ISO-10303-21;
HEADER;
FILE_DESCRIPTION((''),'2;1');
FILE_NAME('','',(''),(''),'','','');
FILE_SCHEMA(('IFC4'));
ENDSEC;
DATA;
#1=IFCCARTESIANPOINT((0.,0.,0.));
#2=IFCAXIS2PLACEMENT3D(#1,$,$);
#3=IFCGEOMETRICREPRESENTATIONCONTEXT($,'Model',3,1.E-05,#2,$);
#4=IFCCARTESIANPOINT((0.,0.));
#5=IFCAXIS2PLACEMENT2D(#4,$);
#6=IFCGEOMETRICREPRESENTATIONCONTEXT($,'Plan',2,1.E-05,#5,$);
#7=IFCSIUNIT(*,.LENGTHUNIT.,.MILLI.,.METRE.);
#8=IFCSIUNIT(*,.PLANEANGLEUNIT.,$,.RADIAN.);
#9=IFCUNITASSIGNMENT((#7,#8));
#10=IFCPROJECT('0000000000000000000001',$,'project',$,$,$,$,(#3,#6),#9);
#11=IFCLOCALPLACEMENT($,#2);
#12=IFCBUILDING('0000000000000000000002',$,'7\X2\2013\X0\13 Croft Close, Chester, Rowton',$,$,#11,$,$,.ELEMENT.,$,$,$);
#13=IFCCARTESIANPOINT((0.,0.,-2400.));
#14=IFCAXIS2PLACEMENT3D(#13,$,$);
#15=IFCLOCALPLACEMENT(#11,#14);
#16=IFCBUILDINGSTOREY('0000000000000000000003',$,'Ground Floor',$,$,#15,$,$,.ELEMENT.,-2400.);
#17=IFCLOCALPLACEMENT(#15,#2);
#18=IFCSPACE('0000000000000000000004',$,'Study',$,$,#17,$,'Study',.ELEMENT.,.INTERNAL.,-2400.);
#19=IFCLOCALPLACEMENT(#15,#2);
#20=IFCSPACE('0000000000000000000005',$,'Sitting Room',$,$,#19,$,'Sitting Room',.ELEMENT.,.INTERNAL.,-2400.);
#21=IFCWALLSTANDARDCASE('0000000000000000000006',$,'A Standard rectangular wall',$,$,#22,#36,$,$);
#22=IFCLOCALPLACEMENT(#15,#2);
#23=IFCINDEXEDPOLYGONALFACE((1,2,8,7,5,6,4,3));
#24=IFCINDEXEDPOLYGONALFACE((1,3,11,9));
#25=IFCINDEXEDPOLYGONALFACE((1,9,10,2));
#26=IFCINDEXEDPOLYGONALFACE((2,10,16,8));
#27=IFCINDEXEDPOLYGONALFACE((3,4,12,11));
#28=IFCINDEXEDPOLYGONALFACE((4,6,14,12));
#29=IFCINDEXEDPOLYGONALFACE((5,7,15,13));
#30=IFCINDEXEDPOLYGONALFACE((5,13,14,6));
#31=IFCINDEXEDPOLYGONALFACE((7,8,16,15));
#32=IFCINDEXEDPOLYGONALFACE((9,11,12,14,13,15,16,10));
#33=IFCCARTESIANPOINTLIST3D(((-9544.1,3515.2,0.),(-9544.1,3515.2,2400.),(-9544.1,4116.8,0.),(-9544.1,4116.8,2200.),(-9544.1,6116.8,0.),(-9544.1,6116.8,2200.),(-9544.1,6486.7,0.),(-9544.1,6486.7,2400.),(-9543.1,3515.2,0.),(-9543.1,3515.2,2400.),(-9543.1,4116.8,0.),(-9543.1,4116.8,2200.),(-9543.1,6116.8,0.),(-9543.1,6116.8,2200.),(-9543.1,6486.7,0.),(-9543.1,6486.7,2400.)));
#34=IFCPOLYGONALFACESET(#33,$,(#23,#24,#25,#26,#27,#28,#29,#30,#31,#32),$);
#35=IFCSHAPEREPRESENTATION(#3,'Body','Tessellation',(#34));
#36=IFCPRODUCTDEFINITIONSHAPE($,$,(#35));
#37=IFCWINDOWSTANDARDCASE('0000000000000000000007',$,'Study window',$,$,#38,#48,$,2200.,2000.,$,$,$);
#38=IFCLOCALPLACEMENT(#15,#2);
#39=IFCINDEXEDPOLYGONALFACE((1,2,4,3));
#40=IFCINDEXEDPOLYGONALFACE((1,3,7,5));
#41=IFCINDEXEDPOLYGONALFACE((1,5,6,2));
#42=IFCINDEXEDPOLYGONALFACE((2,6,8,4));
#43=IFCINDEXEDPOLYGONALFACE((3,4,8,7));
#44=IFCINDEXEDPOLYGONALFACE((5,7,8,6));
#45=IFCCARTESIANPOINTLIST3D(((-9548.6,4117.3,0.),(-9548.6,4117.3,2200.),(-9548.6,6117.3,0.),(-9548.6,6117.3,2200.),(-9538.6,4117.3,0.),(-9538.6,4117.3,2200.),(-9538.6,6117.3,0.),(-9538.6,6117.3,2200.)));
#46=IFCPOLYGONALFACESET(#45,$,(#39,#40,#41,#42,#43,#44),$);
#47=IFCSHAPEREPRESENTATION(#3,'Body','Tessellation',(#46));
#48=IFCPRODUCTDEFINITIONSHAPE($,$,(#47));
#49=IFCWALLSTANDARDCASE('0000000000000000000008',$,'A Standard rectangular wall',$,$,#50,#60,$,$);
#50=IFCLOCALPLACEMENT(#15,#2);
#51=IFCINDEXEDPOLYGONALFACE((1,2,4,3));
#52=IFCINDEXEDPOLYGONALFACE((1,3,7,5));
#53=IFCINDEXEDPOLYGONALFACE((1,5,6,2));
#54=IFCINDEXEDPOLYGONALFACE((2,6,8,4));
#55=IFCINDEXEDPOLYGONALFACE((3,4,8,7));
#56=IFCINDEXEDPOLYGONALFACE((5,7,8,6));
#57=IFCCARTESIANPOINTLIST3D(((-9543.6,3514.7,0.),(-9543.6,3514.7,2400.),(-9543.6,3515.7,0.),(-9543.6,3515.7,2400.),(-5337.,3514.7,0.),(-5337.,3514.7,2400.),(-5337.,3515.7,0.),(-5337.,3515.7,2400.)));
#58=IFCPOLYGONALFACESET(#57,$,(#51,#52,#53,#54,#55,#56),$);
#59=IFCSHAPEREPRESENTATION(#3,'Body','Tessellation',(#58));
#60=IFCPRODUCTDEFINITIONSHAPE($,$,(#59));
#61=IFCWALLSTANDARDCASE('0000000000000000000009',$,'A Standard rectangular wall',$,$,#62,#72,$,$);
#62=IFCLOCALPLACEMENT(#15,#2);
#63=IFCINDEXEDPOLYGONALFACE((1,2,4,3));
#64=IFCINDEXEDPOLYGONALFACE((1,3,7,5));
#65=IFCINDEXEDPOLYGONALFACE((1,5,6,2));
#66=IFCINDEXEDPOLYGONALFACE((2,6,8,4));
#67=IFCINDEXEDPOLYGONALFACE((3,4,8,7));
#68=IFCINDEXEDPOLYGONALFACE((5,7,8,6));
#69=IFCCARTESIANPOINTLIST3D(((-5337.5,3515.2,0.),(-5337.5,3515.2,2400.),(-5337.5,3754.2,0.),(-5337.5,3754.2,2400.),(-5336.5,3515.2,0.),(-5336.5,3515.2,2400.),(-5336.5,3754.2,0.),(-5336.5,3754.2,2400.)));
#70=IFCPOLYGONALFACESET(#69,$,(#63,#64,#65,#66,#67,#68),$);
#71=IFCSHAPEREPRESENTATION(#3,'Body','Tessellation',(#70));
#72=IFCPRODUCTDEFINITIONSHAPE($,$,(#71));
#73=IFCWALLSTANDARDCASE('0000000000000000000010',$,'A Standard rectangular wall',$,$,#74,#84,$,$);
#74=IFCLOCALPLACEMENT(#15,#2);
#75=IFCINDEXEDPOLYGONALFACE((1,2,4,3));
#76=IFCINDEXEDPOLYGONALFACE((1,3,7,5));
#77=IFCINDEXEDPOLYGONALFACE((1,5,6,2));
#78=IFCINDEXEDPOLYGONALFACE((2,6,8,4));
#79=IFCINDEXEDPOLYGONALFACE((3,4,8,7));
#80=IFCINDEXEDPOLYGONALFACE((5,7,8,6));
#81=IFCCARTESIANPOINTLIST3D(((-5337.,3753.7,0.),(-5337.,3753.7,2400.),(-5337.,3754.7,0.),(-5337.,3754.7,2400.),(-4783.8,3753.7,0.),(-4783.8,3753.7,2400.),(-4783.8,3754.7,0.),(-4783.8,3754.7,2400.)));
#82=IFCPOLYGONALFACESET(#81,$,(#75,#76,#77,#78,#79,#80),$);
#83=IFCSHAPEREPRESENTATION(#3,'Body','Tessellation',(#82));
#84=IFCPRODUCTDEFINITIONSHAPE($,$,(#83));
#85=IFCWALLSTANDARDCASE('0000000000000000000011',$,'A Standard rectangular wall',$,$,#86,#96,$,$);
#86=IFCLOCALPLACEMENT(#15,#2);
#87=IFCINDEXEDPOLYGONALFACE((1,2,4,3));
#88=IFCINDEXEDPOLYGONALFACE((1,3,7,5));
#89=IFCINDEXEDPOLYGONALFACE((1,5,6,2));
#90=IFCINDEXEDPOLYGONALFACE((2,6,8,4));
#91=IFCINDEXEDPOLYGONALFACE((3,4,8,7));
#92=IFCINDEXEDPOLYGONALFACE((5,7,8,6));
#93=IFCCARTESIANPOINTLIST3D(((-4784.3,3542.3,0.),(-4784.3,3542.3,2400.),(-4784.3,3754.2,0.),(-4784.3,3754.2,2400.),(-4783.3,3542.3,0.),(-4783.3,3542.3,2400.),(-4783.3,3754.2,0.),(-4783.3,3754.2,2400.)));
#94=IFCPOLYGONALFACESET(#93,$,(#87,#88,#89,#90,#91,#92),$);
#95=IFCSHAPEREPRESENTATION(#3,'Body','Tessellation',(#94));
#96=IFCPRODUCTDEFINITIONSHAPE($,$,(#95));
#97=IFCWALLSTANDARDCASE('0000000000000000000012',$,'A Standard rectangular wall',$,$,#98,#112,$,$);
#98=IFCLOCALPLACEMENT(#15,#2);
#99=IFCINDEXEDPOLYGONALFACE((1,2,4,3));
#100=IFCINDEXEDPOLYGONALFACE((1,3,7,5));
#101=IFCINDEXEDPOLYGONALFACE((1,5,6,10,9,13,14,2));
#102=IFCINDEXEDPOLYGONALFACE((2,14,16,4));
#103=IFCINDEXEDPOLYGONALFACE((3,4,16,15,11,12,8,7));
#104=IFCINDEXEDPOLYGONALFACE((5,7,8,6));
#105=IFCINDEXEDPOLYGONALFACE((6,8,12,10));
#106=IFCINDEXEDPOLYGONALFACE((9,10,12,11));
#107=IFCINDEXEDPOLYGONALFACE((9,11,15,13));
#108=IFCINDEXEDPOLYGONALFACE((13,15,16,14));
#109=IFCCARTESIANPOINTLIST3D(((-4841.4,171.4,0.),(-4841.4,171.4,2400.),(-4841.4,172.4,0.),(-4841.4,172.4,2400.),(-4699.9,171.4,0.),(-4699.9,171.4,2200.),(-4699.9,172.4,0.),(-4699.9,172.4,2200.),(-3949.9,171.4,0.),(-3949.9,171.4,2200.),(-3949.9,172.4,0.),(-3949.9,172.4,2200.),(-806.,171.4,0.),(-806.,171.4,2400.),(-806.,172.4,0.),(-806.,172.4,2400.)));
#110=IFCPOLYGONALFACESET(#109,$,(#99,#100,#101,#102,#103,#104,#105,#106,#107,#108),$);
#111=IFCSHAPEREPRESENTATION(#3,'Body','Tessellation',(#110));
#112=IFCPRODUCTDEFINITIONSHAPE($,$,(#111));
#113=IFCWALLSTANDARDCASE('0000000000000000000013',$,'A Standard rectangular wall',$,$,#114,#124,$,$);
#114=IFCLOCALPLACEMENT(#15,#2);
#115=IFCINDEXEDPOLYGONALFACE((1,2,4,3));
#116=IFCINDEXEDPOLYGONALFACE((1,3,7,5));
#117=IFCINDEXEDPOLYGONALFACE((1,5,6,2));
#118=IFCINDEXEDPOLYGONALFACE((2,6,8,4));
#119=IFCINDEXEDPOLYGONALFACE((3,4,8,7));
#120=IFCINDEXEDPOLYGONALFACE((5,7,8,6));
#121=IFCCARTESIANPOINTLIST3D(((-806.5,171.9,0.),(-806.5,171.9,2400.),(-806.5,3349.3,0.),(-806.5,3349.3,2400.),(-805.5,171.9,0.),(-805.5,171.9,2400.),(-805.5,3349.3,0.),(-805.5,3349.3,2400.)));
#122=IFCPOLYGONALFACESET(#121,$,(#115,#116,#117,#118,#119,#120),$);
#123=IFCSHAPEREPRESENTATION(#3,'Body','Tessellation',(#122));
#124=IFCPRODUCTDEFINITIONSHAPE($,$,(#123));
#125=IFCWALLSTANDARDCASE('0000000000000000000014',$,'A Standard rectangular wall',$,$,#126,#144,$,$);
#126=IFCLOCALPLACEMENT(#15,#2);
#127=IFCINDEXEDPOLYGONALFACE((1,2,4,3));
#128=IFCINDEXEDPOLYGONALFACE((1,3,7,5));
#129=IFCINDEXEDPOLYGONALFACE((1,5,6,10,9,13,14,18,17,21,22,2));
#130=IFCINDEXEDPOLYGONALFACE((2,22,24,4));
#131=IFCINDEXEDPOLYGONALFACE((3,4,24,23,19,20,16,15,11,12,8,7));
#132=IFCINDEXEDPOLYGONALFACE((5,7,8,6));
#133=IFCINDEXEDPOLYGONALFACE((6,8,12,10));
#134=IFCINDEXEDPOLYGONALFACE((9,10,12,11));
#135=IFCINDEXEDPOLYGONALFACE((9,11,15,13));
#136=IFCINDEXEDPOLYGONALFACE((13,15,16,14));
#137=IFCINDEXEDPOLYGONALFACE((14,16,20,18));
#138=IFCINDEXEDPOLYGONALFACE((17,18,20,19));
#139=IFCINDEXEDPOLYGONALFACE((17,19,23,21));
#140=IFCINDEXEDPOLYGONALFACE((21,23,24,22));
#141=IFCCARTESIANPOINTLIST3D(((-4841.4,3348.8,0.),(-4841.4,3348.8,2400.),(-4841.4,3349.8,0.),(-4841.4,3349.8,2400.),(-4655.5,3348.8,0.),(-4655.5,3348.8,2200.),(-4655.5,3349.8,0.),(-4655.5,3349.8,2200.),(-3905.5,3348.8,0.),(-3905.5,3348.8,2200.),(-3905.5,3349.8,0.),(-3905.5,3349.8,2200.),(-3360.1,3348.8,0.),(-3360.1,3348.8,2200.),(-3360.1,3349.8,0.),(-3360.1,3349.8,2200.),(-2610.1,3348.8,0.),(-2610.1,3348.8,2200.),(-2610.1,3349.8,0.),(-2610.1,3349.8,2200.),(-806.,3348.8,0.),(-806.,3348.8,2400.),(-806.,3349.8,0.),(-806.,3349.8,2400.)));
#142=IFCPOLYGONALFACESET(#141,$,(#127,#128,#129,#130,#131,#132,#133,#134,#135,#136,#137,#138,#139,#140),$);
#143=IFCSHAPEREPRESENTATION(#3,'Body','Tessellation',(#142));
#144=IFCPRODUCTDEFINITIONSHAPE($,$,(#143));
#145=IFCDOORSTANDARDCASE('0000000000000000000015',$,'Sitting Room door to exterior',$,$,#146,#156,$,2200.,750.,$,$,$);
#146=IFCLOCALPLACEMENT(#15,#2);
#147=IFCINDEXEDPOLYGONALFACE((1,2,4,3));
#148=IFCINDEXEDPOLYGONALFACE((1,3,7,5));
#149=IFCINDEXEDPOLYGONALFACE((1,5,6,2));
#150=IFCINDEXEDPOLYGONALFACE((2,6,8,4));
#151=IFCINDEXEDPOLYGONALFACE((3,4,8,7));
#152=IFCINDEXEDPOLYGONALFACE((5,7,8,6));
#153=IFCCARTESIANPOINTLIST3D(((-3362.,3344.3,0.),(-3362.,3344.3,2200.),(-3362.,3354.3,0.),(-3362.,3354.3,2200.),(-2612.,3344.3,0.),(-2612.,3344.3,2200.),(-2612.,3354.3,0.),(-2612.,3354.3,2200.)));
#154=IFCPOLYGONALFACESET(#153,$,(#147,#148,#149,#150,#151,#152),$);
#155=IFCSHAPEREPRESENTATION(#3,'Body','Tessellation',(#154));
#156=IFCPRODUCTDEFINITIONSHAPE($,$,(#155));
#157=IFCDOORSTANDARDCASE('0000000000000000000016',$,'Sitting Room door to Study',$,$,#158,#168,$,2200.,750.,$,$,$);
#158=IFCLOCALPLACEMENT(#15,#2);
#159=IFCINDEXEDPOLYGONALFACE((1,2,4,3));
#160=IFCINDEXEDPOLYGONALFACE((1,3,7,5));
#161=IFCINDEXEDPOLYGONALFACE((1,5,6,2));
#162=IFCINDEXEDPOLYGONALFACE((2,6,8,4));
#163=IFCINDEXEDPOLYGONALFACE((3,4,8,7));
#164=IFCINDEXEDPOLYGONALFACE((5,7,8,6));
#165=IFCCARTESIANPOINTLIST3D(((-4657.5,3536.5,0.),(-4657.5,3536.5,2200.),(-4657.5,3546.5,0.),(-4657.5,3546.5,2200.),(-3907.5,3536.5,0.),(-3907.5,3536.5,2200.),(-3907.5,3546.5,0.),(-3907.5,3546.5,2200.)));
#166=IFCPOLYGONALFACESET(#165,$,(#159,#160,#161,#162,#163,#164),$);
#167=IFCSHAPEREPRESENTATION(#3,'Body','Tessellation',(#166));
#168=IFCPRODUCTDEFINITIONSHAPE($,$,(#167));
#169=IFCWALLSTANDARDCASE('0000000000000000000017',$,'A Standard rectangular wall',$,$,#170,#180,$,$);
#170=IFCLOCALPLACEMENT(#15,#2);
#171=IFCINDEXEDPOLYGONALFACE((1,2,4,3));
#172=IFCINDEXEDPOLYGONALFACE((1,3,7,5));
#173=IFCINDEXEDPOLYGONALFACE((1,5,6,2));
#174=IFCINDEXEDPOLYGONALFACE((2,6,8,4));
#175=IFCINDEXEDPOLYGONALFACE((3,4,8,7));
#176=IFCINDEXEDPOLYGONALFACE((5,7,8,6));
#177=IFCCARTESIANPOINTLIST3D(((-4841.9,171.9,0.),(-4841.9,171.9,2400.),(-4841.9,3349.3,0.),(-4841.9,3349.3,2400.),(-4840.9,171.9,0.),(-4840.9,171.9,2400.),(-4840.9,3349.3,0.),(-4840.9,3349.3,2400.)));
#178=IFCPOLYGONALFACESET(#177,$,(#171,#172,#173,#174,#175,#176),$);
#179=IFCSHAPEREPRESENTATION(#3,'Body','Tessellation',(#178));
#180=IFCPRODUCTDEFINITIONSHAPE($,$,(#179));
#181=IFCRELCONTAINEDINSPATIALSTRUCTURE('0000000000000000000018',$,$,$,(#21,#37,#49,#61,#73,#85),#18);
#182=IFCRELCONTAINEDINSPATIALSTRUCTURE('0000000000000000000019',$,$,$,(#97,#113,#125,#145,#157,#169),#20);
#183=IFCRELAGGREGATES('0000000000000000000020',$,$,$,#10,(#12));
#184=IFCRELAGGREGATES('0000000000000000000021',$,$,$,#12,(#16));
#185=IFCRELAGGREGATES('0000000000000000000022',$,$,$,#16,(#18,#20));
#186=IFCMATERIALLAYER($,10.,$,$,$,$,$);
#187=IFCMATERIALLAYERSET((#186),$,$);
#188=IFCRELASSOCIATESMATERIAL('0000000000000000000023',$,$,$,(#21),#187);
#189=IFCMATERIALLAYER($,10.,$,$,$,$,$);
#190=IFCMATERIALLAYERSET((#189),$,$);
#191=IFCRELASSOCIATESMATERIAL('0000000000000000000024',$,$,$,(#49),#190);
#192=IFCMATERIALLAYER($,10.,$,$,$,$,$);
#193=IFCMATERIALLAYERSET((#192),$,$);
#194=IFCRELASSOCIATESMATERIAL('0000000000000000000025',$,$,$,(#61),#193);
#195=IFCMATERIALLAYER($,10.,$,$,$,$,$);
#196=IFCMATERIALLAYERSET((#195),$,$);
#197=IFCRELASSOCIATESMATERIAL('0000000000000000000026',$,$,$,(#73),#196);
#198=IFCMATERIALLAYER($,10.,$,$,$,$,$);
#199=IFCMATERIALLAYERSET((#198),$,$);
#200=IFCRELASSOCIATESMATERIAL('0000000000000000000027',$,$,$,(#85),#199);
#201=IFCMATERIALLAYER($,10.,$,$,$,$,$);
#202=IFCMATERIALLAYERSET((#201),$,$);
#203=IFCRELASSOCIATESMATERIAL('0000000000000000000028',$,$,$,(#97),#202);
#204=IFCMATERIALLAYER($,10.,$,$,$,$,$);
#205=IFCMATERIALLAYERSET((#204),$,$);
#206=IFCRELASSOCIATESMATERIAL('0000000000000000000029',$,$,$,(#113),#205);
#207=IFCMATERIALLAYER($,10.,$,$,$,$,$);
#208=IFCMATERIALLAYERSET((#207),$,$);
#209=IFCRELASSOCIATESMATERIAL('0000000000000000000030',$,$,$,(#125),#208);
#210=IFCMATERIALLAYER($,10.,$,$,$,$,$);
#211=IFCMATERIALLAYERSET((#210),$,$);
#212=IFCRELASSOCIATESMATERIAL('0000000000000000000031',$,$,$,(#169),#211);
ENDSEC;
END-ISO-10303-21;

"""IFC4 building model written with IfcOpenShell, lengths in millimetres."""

from ifc_helpers import new_model, si_unit, frame, origin, origin_2d, place, context, project, spatial, rectangle, extrude, layer, layer_set, layer_usage, element, fill, save


model = new_model("IFC4")

# Units and contexts
model_context = context("Model", 3, precision=1e-05, world=origin())
plan_context = context("Plan", 2, precision=1e-05, world=origin_2d())
ifc_project = project(units=[si_unit("LENGTHUNIT", "METRE", prefix="MILLI"), si_unit("PLANEANGLEUNIT", "RADIAN")], contexts=[model_context, plan_context])

# Building, storey, space
building_placement = place(None, origin())
building = spatial("IfcBuilding", under=ifc_project, at=building_placement, Name="7–13 Croft Close, Chester, Rowton", CompositionType="ELEMENT")
storey_placement = place(building_placement, frame((0.0, 0.0, -2400.0)))
storey = spatial("IfcBuildingStorey", under=building, at=storey_placement, Name="Ground Floor", CompositionType="ELEMENT", Elevation=-2400.0)
space_1_placement = place(storey_placement, origin())
space_1 = spatial("IfcSpace", under=storey, at=space_1_placement, Name="Study", LongName="Study", CompositionType="ELEMENT", PredefinedType="INTERNAL", ElevationWithFlooring=-2400.0)

# Shared definitions
space_2_placement = place(storey_placement, origin())
space_2 = spatial("IfcSpace", under=storey, at=space_2_placement, Name="Sitting Room", LongName="Sitting Room", CompositionType="ELEMENT", PredefinedType="INTERNAL", ElevationWithFlooring=-2400.0)

# Wall, opening, window
ifc_layer_1 = layer(None, 10.0)
ifc_layer_set_1 = layer_set([ifc_layer_1])
ifc_layer_usage_1 = layer_usage(ifc_layer_set_1, "AXIS2", "NEGATIVE", 150.0)
wall_1_placement = place(storey_placement, origin())
wall_1 = element("IfcWallStandardCase", 1, at=wall_1_placement, inside=space_1, material=ifc_layer_usage_1, Name="A Standard rectangular wall", context=model_context, shape_type="SweptSolid", body=[
    extrude(rectangle(XDim=1.0, YDim=2971.5, at=origin_2d()), frame((-9543.6, 5001.0, 0.0), x_axis=(1.0, 0.0, 0.0)), (0.0, 0.0, 1.0), 2400.0),
])
opening_1_placement = place(storey_placement, origin())
opening_1 = element("IfcOpeningElement", 2, at=opening_1_placement, cuts=wall_1, context=model_context, shape_type="SweptSolid", body=[
    extrude(rectangle(XDim=10.0, YDim=2000.0, at=origin_2d()), frame((-9543.6, 5116.8, 0.0), x_axis=(1.0, 0.0, 0.0)), (0.0, 0.0, 1.0), 2200.0),
])
window_1_placement = place(storey_placement, frame((0.0, 0.5, 0.0)))
window_1 = element("IfcWindowStandardCase", 3, at=window_1_placement, inside=space_1, Name="Study window", OverallHeight=2200.0, OverallWidth=2000.0, context=model_context, shape_type="SweptSolid", body=[
    extrude(rectangle(XDim=10.0, YDim=2000.0, at=origin_2d()), frame((-9543.6, 5116.8, 0.0), x_axis=(1.0, 0.0, 0.0)), (0.0, 0.0, 1.0), 2200.0),
])
fill(opening_1, window_1)

# Walls
ifc_layer_2 = layer(None, 10.0)
ifc_layer_set_2 = layer_set([ifc_layer_2])
ifc_layer_usage_2 = layer_usage(ifc_layer_set_2, "AXIS2", "NEGATIVE", 150.0)
wall_2_placement = place(storey_placement, origin())
element("IfcWallStandardCase", 4, at=wall_2_placement, inside=space_1, material=ifc_layer_usage_2, Name="A Standard rectangular wall", context=model_context, shape_type="SweptSolid", body=[
    extrude(rectangle(XDim=1.0, YDim=4206.6, at=origin_2d()), frame((-7440.3, 3515.2, 0.0), x_axis=(0.0, 1.0, 0.0)), (0.0, 0.0, 1.0), 2400.0),
])
ifc_layer_3 = layer(None, 10.0)
ifc_layer_set_3 = layer_set([ifc_layer_3])
ifc_layer_usage_3 = layer_usage(ifc_layer_set_3, "AXIS2", "NEGATIVE", 150.0)
wall_3_placement = place(storey_placement, origin())
element("IfcWallStandardCase", 5, at=wall_3_placement, inside=space_1, material=ifc_layer_usage_3, Name="A Standard rectangular wall", context=model_context, shape_type="SweptSolid", body=[
    extrude(rectangle(XDim=1.0, YDim=239.0, at=origin_2d()), frame((-5337.0, 3634.7, 0.0), x_axis=(-1.0, 0.0, 0.0)), (0.0, 0.0, 1.0), 2400.0),
])
ifc_layer_4 = layer(None, 10.0)
ifc_layer_set_4 = layer_set([ifc_layer_4])
ifc_layer_usage_4 = layer_usage(ifc_layer_set_4, "AXIS2", "NEGATIVE", 150.0)
wall_4_placement = place(storey_placement, origin())
element("IfcWallStandardCase", 6, at=wall_4_placement, inside=space_1, material=ifc_layer_usage_4, Name="A Standard rectangular wall", context=model_context, shape_type="SweptSolid", body=[
    extrude(rectangle(XDim=1.0, YDim=553.2, at=origin_2d()), frame((-5060.4, 3754.2, 0.0), x_axis=(0.0, 1.0, 0.0)), (0.0, 0.0, 1.0), 2400.0),
])
ifc_layer_5 = layer(None, 10.0)
ifc_layer_set_5 = layer_set([ifc_layer_5])
ifc_layer_usage_5 = layer_usage(ifc_layer_set_5, "AXIS2", "NEGATIVE", 150.0)
wall_5_placement = place(storey_placement, origin())
element("IfcWallStandardCase", 7, at=wall_5_placement, inside=space_1, material=ifc_layer_usage_5, Name="A Standard rectangular wall", context=model_context, shape_type="SweptSolid", body=[
    extrude(rectangle(XDim=1.0, YDim=211.9, at=origin_2d()), frame((-4783.8, 3648.2, 0.0), x_axis=(1.0, 0.0, 0.0)), (0.0, 0.0, 1.0), 2400.0),
])

# Wall, opening
ifc_layer_6 = layer(None, 10.0)
ifc_layer_set_6 = layer_set([ifc_layer_6])
ifc_layer_usage_6 = layer_usage(ifc_layer_set_6, "AXIS2", "NEGATIVE", 150.0)
wall_6_placement = place(storey_placement, origin())
wall_6 = element("IfcWallStandardCase", 8, at=wall_6_placement, inside=space_2, material=ifc_layer_usage_6, Name="A Standard rectangular wall", context=model_context, shape_type="SweptSolid", body=[
    extrude(rectangle(XDim=1.0, YDim=4035.4, at=origin_2d()), frame((-2823.7, 171.9, 0.0), x_axis=(0.0, 1.0, 0.0)), (0.0, 0.0, 1.0), 2400.0),
])
opening_2_placement = place(storey_placement, origin())
element("IfcOpeningElement", 9, at=opening_2_placement, cuts=wall_6, context=model_context, shape_type="SweptSolid", body=[
    extrude(rectangle(XDim=10.0, YDim=750.0, at=origin_2d()), frame((-4324.9, 171.9, 0.0), x_axis=(0.0, -1.0, 0.0)), (0.0, 0.0, 1.0), 2200.0),
])

# Wall
ifc_layer_7 = layer(None, 10.0)
ifc_layer_set_7 = layer_set([ifc_layer_7])
ifc_layer_usage_7 = layer_usage(ifc_layer_set_7, "AXIS2", "NEGATIVE", 150.0)
wall_7_placement = place(storey_placement, origin())
element("IfcWallStandardCase", 10, at=wall_7_placement, inside=space_2, material=ifc_layer_usage_7, Name="A Standard rectangular wall", context=model_context, shape_type="SweptSolid", body=[
    extrude(rectangle(XDim=1.0, YDim=3177.4, at=origin_2d()), frame((-806.0, 1760.6, 0.0), x_axis=(-1.0, 0.0, 0.0)), (0.0, 0.0, 1.0), 2400.0),
])

# Wall, openings, doors
ifc_layer_8 = layer(None, 10.0)
ifc_layer_set_8 = layer_set([ifc_layer_8])
ifc_layer_usage_8 = layer_usage(ifc_layer_set_8, "AXIS2", "NEGATIVE", 150.0)
wall_8_placement = place(storey_placement, origin())
wall_8 = element("IfcWallStandardCase", 11, at=wall_8_placement, inside=space_2, material=ifc_layer_usage_8, Name="A Standard rectangular wall", context=model_context, shape_type="SweptSolid", body=[
    extrude(rectangle(XDim=1.0, YDim=4035.4, at=origin_2d()), frame((-2823.7, 3349.3, 0.0), x_axis=(0.0, -1.0, 0.0)), (0.0, 0.0, 1.0), 2400.0),
])
opening_3_placement = place(storey_placement, origin())
opening_3 = element("IfcOpeningElement", 12, at=opening_3_placement, cuts=wall_8, context=model_context, shape_type="SweptSolid", body=[
    extrude(rectangle(XDim=10.0, YDim=750.0, at=origin_2d()), frame((-2985.1, 3349.3, 0.0), x_axis=(0.0, -1.0, 0.0)), (0.0, 0.0, 1.0), 2200.0),
])
opening_4_placement = place(storey_placement, origin())
opening_4 = element("IfcOpeningElement", 13, at=opening_4_placement, cuts=wall_8, context=model_context, shape_type="SweptSolid", body=[
    extrude(rectangle(XDim=10.0, YDim=750.0, at=origin_2d()), frame((-4280.5, 3349.3, 0.0), x_axis=(0.0, -1.0, 0.0)), (0.0, 0.0, 1.0), 2200.0),
])
door_1_placement = place(storey_placement, frame((-1.9, 0.0, 0.0)))
door_1 = element("IfcDoorStandardCase", 14, at=door_1_placement, inside=space_2, Name="Sitting Room door to exterior", OverallHeight=2200.0, OverallWidth=750.0, context=model_context, shape_type="SweptSolid", body=[
    extrude(rectangle(XDim=10.0, YDim=750.0, at=origin_2d()), frame((-2985.1, 3349.3, 0.0), x_axis=(0.0, -1.0, 0.0)), (0.0, 0.0, 1.0), 2200.0),
])
fill(opening_3, door_1)
door_2_placement = place(storey_placement, frame((-2.0, 192.2, 0.0)))
door_2 = element("IfcDoorStandardCase", 15, at=door_2_placement, inside=space_2, Name="Sitting Room door to Study", OverallHeight=2200.0, OverallWidth=750.0, context=model_context, shape_type="SweptSolid", body=[
    extrude(rectangle(XDim=10.0, YDim=750.0, at=origin_2d()), frame((-4280.5, 3349.3, 0.0), x_axis=(0.0, -1.0, 0.0)), (0.0, 0.0, 1.0), 2200.0),
])
fill(opening_4, door_2)

# Wall
ifc_layer_9 = layer(None, 10.0)
ifc_layer_set_9 = layer_set([ifc_layer_9])
ifc_layer_usage_9 = layer_usage(ifc_layer_set_9, "AXIS2", "NEGATIVE", 150.0)
wall_9_placement = place(storey_placement, origin())
element("IfcWallStandardCase", 16, at=wall_9_placement, inside=space_2, material=ifc_layer_usage_9, Name="A Standard rectangular wall", context=model_context, shape_type="SweptSolid", body=[
    extrude(rectangle(XDim=1.0, YDim=3177.4, at=origin_2d()), frame((-4841.4, 1760.6, 0.0), x_axis=(1.0, 0.0, 0.0)), (0.0, 0.0, 1.0), 2400.0),
])

save(model, "model.ifc")
